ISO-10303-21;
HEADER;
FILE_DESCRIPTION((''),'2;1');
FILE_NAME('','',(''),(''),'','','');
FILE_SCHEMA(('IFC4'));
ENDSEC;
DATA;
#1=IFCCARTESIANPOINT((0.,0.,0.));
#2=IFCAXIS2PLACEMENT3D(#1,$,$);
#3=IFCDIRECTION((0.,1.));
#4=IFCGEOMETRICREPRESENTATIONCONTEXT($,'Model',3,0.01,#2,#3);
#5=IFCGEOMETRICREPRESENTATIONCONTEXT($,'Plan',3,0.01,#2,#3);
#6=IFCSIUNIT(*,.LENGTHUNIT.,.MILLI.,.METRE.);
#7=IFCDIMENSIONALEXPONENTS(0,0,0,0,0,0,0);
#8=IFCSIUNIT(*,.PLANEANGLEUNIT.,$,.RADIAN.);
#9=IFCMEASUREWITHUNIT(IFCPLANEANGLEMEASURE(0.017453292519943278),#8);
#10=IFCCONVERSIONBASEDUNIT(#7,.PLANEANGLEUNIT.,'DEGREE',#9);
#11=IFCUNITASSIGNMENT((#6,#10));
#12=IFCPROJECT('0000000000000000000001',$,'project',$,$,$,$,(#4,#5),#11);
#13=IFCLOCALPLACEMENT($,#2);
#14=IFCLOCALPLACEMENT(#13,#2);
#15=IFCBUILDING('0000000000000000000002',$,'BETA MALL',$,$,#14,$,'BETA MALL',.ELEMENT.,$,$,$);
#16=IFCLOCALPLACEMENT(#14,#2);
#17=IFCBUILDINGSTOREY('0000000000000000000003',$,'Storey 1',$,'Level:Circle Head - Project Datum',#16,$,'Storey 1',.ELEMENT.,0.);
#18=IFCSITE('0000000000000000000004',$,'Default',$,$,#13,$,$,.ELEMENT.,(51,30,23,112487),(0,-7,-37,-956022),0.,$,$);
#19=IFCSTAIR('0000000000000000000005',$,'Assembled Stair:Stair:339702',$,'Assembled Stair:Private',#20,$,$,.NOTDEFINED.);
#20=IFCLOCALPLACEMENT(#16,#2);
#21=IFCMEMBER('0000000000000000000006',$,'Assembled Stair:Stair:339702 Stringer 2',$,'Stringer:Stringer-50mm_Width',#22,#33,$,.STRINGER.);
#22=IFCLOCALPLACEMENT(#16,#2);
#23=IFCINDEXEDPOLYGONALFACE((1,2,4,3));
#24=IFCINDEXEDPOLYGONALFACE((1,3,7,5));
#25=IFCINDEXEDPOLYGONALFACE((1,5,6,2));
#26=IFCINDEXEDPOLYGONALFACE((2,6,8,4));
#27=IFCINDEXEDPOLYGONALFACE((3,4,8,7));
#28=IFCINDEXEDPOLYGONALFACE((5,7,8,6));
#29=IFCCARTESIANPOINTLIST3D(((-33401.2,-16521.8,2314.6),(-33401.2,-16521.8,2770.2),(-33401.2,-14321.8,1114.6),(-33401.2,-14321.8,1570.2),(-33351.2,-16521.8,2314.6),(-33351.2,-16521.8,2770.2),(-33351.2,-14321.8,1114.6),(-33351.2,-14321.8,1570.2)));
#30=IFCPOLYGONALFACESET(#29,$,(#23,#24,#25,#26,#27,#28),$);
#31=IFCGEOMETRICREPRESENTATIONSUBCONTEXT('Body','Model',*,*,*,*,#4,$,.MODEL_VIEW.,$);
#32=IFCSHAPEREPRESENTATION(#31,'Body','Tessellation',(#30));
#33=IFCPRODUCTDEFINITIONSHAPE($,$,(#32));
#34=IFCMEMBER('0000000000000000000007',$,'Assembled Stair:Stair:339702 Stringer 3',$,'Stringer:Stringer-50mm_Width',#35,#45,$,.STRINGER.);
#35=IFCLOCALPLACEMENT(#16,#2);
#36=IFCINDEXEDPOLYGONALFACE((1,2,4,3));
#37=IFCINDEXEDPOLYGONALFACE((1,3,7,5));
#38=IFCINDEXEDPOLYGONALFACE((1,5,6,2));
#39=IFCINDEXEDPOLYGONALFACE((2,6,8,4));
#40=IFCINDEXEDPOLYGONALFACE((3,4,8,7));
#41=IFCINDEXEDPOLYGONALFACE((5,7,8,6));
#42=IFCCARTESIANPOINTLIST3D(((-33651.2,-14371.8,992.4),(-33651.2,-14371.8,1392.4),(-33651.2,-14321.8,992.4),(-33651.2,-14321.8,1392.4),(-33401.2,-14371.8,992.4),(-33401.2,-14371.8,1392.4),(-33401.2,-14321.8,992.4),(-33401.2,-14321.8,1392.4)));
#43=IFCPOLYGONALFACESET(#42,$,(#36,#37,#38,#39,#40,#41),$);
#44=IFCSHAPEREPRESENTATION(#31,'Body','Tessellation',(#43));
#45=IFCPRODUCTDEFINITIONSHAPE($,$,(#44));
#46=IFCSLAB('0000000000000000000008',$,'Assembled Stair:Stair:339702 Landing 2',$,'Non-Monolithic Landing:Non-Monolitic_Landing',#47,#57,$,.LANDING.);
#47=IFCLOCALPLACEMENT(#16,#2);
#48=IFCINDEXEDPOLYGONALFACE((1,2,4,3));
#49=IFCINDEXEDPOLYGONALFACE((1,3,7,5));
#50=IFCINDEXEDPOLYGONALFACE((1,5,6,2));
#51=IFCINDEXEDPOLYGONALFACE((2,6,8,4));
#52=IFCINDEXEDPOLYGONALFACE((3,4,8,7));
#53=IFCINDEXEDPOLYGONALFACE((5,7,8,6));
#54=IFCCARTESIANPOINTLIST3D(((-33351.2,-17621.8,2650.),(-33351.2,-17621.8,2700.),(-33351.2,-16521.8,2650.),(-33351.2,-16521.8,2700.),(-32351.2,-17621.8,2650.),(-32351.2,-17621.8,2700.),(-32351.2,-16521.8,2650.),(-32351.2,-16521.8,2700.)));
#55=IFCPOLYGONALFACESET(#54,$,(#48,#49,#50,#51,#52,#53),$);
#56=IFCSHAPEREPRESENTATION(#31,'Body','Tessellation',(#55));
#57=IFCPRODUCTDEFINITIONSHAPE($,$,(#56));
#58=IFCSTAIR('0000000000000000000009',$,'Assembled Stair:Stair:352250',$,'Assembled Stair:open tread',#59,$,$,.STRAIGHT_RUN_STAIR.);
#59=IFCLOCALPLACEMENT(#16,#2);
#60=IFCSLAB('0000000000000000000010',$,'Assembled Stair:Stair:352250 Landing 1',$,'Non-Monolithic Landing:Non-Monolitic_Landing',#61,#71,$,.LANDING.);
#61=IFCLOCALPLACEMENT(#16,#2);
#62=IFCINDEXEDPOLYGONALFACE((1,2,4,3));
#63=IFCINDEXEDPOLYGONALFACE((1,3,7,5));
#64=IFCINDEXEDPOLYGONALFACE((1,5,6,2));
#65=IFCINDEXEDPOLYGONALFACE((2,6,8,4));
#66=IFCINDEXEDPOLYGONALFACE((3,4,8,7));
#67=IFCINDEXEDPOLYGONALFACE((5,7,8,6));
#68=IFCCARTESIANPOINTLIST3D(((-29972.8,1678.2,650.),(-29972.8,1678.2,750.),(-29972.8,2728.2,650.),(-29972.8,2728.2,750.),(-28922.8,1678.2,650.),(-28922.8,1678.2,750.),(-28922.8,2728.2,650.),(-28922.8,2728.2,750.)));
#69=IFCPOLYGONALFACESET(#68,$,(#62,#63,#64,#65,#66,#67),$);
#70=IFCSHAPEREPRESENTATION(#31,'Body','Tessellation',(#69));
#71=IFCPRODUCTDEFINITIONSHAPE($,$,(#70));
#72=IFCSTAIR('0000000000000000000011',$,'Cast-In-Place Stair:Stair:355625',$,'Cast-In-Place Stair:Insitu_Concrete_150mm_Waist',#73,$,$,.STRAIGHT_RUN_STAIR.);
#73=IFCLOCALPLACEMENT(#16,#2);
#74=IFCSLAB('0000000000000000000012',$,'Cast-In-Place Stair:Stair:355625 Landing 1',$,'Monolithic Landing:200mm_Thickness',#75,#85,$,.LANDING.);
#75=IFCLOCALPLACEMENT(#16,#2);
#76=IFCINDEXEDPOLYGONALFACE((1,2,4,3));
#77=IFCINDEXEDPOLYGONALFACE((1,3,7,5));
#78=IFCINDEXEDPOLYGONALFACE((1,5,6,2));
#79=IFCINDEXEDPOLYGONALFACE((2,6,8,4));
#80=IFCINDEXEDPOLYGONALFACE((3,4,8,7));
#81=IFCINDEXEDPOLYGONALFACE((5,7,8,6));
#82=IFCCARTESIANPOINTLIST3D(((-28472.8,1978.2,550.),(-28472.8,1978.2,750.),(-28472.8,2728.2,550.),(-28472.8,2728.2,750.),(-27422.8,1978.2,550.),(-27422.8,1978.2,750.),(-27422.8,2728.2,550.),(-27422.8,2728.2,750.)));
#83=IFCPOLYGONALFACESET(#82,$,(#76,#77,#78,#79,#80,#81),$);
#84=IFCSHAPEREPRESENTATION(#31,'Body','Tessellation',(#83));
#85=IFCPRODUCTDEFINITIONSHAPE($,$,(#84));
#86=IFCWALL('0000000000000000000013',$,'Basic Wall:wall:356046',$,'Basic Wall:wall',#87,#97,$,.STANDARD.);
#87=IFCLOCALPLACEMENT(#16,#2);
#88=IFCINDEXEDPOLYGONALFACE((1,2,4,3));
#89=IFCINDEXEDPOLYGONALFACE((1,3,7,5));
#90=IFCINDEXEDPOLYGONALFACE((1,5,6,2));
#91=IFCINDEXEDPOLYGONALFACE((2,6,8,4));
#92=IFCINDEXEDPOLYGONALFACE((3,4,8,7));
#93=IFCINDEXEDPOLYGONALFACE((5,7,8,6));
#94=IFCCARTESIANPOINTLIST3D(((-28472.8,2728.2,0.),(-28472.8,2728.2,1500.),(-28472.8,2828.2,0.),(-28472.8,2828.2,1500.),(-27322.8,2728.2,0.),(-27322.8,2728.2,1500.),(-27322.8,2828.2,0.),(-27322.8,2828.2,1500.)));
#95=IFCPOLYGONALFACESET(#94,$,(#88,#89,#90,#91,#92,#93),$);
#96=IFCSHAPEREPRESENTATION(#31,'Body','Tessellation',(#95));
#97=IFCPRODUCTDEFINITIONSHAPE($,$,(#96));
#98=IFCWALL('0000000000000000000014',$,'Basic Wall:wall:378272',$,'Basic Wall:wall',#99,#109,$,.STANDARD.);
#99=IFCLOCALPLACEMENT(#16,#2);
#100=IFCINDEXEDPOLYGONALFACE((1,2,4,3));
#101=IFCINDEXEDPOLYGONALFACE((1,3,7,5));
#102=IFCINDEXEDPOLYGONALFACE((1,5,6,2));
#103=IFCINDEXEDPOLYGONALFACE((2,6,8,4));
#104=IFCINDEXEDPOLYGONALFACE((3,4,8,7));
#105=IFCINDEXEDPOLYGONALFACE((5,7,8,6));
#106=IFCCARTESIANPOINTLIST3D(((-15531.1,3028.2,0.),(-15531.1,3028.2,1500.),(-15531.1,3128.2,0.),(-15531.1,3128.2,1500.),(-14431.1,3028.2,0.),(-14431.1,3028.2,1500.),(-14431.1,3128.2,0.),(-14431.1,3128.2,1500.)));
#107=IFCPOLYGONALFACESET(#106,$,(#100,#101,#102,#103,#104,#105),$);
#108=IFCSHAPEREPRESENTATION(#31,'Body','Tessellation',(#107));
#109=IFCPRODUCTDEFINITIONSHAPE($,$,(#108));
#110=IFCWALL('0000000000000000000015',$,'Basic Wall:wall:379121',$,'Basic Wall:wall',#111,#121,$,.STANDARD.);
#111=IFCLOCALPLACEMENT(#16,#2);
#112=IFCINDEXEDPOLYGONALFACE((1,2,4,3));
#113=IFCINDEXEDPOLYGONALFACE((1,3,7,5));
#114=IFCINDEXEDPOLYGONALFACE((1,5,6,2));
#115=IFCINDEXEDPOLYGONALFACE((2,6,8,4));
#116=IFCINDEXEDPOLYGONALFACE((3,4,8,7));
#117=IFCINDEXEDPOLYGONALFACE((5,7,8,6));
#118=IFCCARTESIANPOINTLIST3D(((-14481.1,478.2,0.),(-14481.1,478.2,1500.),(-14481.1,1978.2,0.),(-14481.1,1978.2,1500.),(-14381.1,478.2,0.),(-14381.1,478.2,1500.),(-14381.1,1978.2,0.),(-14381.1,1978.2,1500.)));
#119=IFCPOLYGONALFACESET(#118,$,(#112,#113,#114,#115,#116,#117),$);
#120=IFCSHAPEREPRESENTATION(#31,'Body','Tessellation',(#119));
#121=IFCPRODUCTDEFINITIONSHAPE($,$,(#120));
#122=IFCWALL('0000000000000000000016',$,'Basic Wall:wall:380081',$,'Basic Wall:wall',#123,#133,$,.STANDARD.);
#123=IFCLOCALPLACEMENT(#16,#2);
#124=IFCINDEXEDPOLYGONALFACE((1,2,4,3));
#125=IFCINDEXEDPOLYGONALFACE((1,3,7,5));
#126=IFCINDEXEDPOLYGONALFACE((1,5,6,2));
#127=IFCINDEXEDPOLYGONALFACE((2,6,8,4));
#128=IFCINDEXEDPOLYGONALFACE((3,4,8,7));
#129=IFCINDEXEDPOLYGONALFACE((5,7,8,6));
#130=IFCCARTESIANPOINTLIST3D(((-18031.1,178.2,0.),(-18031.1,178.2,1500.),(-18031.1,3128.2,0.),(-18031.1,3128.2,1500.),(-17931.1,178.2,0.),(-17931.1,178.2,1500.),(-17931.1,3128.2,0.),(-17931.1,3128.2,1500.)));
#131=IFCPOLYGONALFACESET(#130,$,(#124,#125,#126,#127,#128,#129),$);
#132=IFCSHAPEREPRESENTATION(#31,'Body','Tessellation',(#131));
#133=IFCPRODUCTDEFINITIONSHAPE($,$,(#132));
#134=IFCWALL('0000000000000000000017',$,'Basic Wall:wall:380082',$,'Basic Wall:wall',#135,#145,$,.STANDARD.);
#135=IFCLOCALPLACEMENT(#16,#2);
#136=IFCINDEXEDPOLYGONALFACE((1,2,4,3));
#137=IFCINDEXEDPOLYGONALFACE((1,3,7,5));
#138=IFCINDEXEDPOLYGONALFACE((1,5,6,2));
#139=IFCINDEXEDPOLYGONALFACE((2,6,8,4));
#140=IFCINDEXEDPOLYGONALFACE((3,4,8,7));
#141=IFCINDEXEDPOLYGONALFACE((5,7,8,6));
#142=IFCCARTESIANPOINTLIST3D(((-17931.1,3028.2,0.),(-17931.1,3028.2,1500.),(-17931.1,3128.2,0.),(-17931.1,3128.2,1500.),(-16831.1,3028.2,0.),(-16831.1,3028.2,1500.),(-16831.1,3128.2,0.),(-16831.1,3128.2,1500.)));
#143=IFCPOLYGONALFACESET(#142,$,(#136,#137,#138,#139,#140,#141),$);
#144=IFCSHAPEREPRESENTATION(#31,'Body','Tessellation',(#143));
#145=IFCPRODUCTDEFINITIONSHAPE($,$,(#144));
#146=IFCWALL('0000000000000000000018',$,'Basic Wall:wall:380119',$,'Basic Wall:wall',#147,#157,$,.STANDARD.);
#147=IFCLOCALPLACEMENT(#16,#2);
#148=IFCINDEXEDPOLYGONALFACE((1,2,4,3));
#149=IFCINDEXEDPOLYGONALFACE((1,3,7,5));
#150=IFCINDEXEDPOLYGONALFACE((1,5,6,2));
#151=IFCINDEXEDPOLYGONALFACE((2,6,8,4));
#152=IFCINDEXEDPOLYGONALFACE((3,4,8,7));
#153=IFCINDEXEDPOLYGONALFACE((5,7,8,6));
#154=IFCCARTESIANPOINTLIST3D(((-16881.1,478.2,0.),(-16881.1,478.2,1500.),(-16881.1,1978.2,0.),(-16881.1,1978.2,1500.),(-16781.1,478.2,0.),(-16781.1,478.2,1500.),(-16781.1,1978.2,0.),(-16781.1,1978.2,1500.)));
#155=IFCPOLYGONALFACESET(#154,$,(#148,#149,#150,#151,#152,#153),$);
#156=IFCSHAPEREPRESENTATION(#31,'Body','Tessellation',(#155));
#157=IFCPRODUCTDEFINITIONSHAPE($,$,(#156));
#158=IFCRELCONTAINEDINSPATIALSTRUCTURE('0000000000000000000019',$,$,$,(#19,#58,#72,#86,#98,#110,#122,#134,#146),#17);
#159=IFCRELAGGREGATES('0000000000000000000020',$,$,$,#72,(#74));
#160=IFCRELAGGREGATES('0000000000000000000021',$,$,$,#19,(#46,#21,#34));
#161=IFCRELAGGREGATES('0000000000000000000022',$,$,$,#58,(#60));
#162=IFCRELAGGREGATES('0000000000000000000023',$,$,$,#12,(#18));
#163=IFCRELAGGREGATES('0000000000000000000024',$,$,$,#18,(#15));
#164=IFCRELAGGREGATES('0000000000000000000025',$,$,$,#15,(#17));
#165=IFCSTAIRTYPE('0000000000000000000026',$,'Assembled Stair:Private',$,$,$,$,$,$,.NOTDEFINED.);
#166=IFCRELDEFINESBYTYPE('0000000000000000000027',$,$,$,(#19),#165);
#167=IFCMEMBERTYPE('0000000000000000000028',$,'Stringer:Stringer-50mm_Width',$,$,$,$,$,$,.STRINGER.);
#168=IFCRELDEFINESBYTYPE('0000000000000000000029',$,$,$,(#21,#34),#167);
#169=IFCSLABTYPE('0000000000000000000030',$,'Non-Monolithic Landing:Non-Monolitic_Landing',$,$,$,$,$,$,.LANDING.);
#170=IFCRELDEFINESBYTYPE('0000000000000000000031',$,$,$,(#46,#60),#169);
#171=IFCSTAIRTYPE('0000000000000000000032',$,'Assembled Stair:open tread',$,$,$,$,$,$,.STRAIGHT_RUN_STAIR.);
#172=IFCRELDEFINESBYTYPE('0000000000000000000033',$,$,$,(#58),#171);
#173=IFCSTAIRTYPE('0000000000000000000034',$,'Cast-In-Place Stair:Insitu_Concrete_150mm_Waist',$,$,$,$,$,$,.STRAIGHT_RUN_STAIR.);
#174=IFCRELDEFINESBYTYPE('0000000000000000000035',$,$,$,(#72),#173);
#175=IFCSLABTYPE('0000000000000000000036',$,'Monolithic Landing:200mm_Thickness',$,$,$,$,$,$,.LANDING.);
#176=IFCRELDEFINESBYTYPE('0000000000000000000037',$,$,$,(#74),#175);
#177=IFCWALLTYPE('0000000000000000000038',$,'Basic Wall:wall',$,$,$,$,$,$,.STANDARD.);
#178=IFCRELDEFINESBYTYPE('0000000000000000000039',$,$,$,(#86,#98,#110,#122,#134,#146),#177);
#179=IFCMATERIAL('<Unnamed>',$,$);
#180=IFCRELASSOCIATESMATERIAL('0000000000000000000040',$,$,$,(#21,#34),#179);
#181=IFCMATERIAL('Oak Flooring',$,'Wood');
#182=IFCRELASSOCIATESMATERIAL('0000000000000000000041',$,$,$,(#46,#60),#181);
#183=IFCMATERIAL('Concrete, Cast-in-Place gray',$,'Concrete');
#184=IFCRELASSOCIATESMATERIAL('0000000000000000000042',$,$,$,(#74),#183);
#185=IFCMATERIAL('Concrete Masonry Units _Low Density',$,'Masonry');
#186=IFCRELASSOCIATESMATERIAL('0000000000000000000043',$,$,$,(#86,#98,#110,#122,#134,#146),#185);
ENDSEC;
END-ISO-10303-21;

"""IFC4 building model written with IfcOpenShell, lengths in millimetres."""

from ifc_helpers import new_model, entity, si_unit, converted_unit, direction, frame, origin, place, context, subcontext, project, spatial, indexed_curve, outline, extrude, material, type_object, element, aggregate, save


model = new_model("IFC4")

# Units and contexts
model_context = context("Model", 3, precision=0.01, world=origin(), true_north=direction((0.0, 1.0)))
plan_context = context("Plan", 3, precision=0.01, world=origin(), true_north=direction((0.0, 1.0)))
body_context = subcontext(model_context, "Body", "Model", "MODEL_VIEW")
ifc_project = project(units=[si_unit("LENGTHUNIT", "METRE", prefix="MILLI"), converted_unit("PLANEANGLEUNIT", "DEGREE", entity("IfcPlaneAngleMeasure", 0.017453292519943278), si_unit("PLANEANGLEUNIT", "RADIAN"), dimensions=[0, 0, 0, 0, 0, 0, 0])], contexts=[model_context, plan_context])

# Site, building, storey
site_placement = place(None, origin())
site = spatial("IfcSite", under=ifc_project, at=site_placement, Name="Default", CompositionType="ELEMENT", RefLatitude=(51, 30, 23, 112487), RefLongitude=(0, -7, -37, -956022), RefElevation=0.0)
building_placement = place(site_placement, origin())
building = spatial("IfcBuilding", under=site, at=building_placement, Name="BETA MALL", LongName="BETA MALL", CompositionType="ELEMENT")
storey_placement = place(building_placement, origin())
storey = spatial("IfcBuildingStorey", under=building, at=storey_placement, Name="Storey 1", ObjectType="Level:Circle Head - Project Datum", LongName="Storey 1", CompositionType="ELEMENT", Elevation=0.0)

# Shared definitions
ifc_material_1 = material(Name="<Unnamed>")

# Stair, members, slab
stair_type_1 = type_object("IfcStairType", Name="Assembled Stair:Private", PredefinedType="NOTDEFINED")
stair_1_placement = place(storey_placement, origin())
stair_1 = element("IfcStair", 1, at=stair_1_placement, inside=storey, type_object=stair_type_1, Name="Assembled Stair:Stair:339702", ObjectType="Assembled Stair:Private", PredefinedType="NOTDEFINED")
member_type = type_object("IfcMemberType", Name="Stringer:Stringer-50mm_Width", PredefinedType="STRINGER")
member_1_placement = place(stair_1_placement, origin())
member_1 = element("IfcMember", 2, at=member_1_placement, type_object=member_type, material=ifc_material_1, Name="Assembled Stair:Stair:339702 Stringer 2", ObjectType="Stringer:Stringer-50mm_Width", PredefinedType="STRINGER", context=body_context, shape_type="SweptSolid", body=[
    extrude(outline(indexed_curve([(-1143.9, -200.0), (1362.1, -200.0), (1143.9, 200.0), (-1362.1, 200.0), (-1143.9, -200.0)], self_intersect=False)), frame((-33401.2, -15421.8, 1942.4), z_axis=(1.0, 0.0, 0.0), x_axis=(0.0, -0.877896, 0.478852)), (0.0, 0.0, 1.0), 50.0),
])
member_2_placement = place(stair_1_placement, origin())
member_2 = element("IfcMember", 3, at=member_2_placement, type_object=member_type, material=ifc_material_1, Name="Assembled Stair:Stair:339702 Stringer 3", ObjectType="Stringer:Stringer-50mm_Width", PredefinedType="STRINGER", context=body_context, shape_type="SweptSolid", body=[
    extrude(outline(indexed_curve([(-125.0, -25.0), (125.0, -25.0), (125.0, 25.0), (-125.0, 25.0), (-125.0, -25.0)], self_intersect=False)), frame((-33526.2, -14346.8, 992.4)), (0.0, 0.0, 1.0), 400.0),
])
ifc_material_2 = material(Name="Oak Flooring", Category="Wood")
slab_type_1 = type_object("IfcSlabType", Name="Non-Monolithic Landing:Non-Monolitic_Landing", PredefinedType="LANDING")
slab_1_placement = place(stair_1_placement, origin())
slab_1 = element("IfcSlab", 4, at=slab_1_placement, type_object=slab_type_1, material=ifc_material_2, Name="Assembled Stair:Stair:339702 Landing 2", ObjectType="Non-Monolithic Landing:Non-Monolitic_Landing", PredefinedType="LANDING", context=body_context, shape_type="SweptSolid", body=[
    extrude(outline(indexed_curve([(-500.0, -550.0), (500.0, -550.0), (500.0, 550.0), (-500.0, 550.0), (-500.0, -550.0)], self_intersect=False)), frame((-32851.2, -17071.8, 2650.0), z_axis=(0.0, 0.0, 1.0), x_axis=(-1.0, 0.0, 0.0)), (0.0, 0.0, 1.0), 50.0),
])

# Stairs, slabs
stair_type_2 = type_object("IfcStairType", Name="Assembled Stair:open tread", PredefinedType="STRAIGHT_RUN_STAIR")
stair_2_placement = place(storey_placement, origin())
stair_2 = element("IfcStair", 5, at=stair_2_placement, inside=storey, type_object=stair_type_2, Name="Assembled Stair:Stair:352250", ObjectType="Assembled Stair:open tread", PredefinedType="STRAIGHT_RUN_STAIR")
slab_2_placement = place(stair_2_placement, origin())
slab_2 = element("IfcSlab", 6, at=slab_2_placement, type_object=slab_type_1, material=ifc_material_2, Name="Assembled Stair:Stair:352250 Landing 1", ObjectType="Non-Monolithic Landing:Non-Monolitic_Landing", PredefinedType="LANDING", context=body_context, shape_type="SweptSolid", body=[
    extrude(outline(indexed_curve([(-525.0, -525.0), (525.0, -525.0), (525.0, 525.0), (-525.0, 525.0), (-525.0, -525.0)], self_intersect=False)), frame((-29447.8, 2203.2, 650.0)), (0.0, 0.0, 1.0), 100.0),
])
ifc_material_3 = material(Name="Concrete, Cast-in-Place gray", Category="Concrete")
slab_type_2 = type_object("IfcSlabType", Name="Monolithic Landing:200mm_Thickness", PredefinedType="LANDING")
stair_type_3 = type_object("IfcStairType", Name="Cast-In-Place Stair:Insitu_Concrete_150mm_Waist", PredefinedType="STRAIGHT_RUN_STAIR")
stair_3_placement = place(storey_placement, origin())
stair_3 = element("IfcStair", 7, at=stair_3_placement, inside=storey, type_object=stair_type_3, Name="Cast-In-Place Stair:Stair:355625", ObjectType="Cast-In-Place Stair:Insitu_Concrete_150mm_Waist", PredefinedType="STRAIGHT_RUN_STAIR")
slab_3_placement = place(stair_3_placement, origin())
slab_3 = element("IfcSlab", 8, at=slab_3_placement, type_object=slab_type_2, material=ifc_material_3, Name="Cast-In-Place Stair:Stair:355625 Landing 1", ObjectType="Monolithic Landing:200mm_Thickness", PredefinedType="LANDING", context=body_context, shape_type="SweptSolid", body=[
    extrude(outline(indexed_curve([(-375.0, -525.0), (375.0, -525.0), (375.0, 525.0), (-375.0, 525.0), (-375.0, -525.0)], self_intersect=False)), frame((-27947.8, 2353.2, 550.0), z_axis=(0.0, 0.0, 1.0), x_axis=(0.0, 1.0, 0.0)), (0.0, 0.0, 1.0), 200.0),
])
aggregate(stair_3, [slab_3])

# Walls
ifc_material_4 = material(Name="Concrete Masonry Units _Low Density", Category="Masonry")
wall_type = type_object("IfcWallType", Name="Basic Wall:wall", PredefinedType="STANDARD")
wall_1_placement = place(storey_placement, frame((-28472.8, 2778.2, 0.0)))
element("IfcWall", 9, at=wall_1_placement, inside=storey, type_object=wall_type, material=ifc_material_4, Name="Basic Wall:wall:356046", ObjectType="Basic Wall:wall", PredefinedType="STANDARD", context=body_context, shape_type="SweptSolid", body=[
    extrude(outline(indexed_curve([(1150.0, 50.0), (0.0, 50.0), (0.0, -50.0), (1150.0, -50.0), (1150.0, 50.0)], self_intersect=False)), origin(), (0.0, 0.0, 1.0), 1500.0),
])
wall_2_placement = place(storey_placement, frame((-15531.1, 3078.2, 0.0)))
element("IfcWall", 10, at=wall_2_placement, inside=storey, type_object=wall_type, material=ifc_material_4, Name="Basic Wall:wall:378272", ObjectType="Basic Wall:wall", PredefinedType="STANDARD", context=body_context, shape_type="SweptSolid", body=[
    extrude(outline(indexed_curve([(1100.0, 50.0), (0.0, 50.0), (0.0, -50.0), (1100.0, -50.0), (1100.0, 50.0)], self_intersect=False)), origin(), (0.0, 0.0, 1.0), 1500.0),
])
wall_3_placement = place(storey_placement, frame((-14431.1, 478.2, 0.0), z_axis=(0.0, 0.0, 1.0), x_axis=(0.0, 1.0, 0.0)))
element("IfcWall", 11, at=wall_3_placement, inside=storey, type_object=wall_type, material=ifc_material_4, Name="Basic Wall:wall:379121", ObjectType="Basic Wall:wall", PredefinedType="STANDARD", context=body_context, shape_type="SweptSolid", body=[
    extrude(outline(indexed_curve([(1500.0, 50.0), (0.0, 50.0), (0.0, -50.0), (1500.0, -50.0), (1500.0, 50.0)], self_intersect=False)), origin(), (0.0, 0.0, 1.0), 1500.0),
])
wall_4_placement = place(storey_placement, frame((-17981.1, 178.2, 0.0), z_axis=(0.0, 0.0, 1.0), x_axis=(0.0, 1.0, 0.0)))
element("IfcWall", 12, at=wall_4_placement, inside=storey, type_object=wall_type, material=ifc_material_4, Name="Basic Wall:wall:380081", ObjectType="Basic Wall:wall", PredefinedType="STANDARD", context=body_context, shape_type="SweptSolid", body=[
    extrude(outline(indexed_curve([(2950.0, 50.0), (0.0, 50.0), (0.0, -50.0), (2950.0, -50.0), (2950.0, 50.0)], self_intersect=False)), origin(), (0.0, 0.0, 1.0), 1500.0),
])
wall_5_placement = place(storey_placement, frame((-17931.1, 3078.2, 0.0)))
element("IfcWall", 13, at=wall_5_placement, inside=storey, type_object=wall_type, material=ifc_material_4, Name="Basic Wall:wall:380082", ObjectType="Basic Wall:wall", PredefinedType="STANDARD", context=body_context, shape_type="SweptSolid", body=[
    extrude(outline(indexed_curve([(1100.0, 50.0), (0.0, 50.0), (0.0, -50.0), (1100.0, -50.0), (1100.0, 50.0)], self_intersect=False)), origin(), (0.0, 0.0, 1.0), 1500.0),
])
wall_6_placement = place(storey_placement, frame((-16831.1, 478.2, 0.0), z_axis=(0.0, 0.0, 1.0), x_axis=(0.0, 1.0, 0.0)))
element("IfcWall", 14, at=wall_6_placement, inside=storey, type_object=wall_type, material=ifc_material_4, Name="Basic Wall:wall:380119", ObjectType="Basic Wall:wall", PredefinedType="STANDARD", context=body_context, shape_type="SweptSolid", body=[
    extrude(outline(indexed_curve([(1500.0, 50.0), (0.0, 50.0), (0.0, -50.0), (1500.0, -50.0), (1500.0, 50.0)], self_intersect=False)), origin(), (0.0, 0.0, 1.0), 1500.0),
])

aggregate(stair_1, [slab_1, member_1, member_2])
aggregate(stair_2, [slab_2])

save(model, "model.ifc")
